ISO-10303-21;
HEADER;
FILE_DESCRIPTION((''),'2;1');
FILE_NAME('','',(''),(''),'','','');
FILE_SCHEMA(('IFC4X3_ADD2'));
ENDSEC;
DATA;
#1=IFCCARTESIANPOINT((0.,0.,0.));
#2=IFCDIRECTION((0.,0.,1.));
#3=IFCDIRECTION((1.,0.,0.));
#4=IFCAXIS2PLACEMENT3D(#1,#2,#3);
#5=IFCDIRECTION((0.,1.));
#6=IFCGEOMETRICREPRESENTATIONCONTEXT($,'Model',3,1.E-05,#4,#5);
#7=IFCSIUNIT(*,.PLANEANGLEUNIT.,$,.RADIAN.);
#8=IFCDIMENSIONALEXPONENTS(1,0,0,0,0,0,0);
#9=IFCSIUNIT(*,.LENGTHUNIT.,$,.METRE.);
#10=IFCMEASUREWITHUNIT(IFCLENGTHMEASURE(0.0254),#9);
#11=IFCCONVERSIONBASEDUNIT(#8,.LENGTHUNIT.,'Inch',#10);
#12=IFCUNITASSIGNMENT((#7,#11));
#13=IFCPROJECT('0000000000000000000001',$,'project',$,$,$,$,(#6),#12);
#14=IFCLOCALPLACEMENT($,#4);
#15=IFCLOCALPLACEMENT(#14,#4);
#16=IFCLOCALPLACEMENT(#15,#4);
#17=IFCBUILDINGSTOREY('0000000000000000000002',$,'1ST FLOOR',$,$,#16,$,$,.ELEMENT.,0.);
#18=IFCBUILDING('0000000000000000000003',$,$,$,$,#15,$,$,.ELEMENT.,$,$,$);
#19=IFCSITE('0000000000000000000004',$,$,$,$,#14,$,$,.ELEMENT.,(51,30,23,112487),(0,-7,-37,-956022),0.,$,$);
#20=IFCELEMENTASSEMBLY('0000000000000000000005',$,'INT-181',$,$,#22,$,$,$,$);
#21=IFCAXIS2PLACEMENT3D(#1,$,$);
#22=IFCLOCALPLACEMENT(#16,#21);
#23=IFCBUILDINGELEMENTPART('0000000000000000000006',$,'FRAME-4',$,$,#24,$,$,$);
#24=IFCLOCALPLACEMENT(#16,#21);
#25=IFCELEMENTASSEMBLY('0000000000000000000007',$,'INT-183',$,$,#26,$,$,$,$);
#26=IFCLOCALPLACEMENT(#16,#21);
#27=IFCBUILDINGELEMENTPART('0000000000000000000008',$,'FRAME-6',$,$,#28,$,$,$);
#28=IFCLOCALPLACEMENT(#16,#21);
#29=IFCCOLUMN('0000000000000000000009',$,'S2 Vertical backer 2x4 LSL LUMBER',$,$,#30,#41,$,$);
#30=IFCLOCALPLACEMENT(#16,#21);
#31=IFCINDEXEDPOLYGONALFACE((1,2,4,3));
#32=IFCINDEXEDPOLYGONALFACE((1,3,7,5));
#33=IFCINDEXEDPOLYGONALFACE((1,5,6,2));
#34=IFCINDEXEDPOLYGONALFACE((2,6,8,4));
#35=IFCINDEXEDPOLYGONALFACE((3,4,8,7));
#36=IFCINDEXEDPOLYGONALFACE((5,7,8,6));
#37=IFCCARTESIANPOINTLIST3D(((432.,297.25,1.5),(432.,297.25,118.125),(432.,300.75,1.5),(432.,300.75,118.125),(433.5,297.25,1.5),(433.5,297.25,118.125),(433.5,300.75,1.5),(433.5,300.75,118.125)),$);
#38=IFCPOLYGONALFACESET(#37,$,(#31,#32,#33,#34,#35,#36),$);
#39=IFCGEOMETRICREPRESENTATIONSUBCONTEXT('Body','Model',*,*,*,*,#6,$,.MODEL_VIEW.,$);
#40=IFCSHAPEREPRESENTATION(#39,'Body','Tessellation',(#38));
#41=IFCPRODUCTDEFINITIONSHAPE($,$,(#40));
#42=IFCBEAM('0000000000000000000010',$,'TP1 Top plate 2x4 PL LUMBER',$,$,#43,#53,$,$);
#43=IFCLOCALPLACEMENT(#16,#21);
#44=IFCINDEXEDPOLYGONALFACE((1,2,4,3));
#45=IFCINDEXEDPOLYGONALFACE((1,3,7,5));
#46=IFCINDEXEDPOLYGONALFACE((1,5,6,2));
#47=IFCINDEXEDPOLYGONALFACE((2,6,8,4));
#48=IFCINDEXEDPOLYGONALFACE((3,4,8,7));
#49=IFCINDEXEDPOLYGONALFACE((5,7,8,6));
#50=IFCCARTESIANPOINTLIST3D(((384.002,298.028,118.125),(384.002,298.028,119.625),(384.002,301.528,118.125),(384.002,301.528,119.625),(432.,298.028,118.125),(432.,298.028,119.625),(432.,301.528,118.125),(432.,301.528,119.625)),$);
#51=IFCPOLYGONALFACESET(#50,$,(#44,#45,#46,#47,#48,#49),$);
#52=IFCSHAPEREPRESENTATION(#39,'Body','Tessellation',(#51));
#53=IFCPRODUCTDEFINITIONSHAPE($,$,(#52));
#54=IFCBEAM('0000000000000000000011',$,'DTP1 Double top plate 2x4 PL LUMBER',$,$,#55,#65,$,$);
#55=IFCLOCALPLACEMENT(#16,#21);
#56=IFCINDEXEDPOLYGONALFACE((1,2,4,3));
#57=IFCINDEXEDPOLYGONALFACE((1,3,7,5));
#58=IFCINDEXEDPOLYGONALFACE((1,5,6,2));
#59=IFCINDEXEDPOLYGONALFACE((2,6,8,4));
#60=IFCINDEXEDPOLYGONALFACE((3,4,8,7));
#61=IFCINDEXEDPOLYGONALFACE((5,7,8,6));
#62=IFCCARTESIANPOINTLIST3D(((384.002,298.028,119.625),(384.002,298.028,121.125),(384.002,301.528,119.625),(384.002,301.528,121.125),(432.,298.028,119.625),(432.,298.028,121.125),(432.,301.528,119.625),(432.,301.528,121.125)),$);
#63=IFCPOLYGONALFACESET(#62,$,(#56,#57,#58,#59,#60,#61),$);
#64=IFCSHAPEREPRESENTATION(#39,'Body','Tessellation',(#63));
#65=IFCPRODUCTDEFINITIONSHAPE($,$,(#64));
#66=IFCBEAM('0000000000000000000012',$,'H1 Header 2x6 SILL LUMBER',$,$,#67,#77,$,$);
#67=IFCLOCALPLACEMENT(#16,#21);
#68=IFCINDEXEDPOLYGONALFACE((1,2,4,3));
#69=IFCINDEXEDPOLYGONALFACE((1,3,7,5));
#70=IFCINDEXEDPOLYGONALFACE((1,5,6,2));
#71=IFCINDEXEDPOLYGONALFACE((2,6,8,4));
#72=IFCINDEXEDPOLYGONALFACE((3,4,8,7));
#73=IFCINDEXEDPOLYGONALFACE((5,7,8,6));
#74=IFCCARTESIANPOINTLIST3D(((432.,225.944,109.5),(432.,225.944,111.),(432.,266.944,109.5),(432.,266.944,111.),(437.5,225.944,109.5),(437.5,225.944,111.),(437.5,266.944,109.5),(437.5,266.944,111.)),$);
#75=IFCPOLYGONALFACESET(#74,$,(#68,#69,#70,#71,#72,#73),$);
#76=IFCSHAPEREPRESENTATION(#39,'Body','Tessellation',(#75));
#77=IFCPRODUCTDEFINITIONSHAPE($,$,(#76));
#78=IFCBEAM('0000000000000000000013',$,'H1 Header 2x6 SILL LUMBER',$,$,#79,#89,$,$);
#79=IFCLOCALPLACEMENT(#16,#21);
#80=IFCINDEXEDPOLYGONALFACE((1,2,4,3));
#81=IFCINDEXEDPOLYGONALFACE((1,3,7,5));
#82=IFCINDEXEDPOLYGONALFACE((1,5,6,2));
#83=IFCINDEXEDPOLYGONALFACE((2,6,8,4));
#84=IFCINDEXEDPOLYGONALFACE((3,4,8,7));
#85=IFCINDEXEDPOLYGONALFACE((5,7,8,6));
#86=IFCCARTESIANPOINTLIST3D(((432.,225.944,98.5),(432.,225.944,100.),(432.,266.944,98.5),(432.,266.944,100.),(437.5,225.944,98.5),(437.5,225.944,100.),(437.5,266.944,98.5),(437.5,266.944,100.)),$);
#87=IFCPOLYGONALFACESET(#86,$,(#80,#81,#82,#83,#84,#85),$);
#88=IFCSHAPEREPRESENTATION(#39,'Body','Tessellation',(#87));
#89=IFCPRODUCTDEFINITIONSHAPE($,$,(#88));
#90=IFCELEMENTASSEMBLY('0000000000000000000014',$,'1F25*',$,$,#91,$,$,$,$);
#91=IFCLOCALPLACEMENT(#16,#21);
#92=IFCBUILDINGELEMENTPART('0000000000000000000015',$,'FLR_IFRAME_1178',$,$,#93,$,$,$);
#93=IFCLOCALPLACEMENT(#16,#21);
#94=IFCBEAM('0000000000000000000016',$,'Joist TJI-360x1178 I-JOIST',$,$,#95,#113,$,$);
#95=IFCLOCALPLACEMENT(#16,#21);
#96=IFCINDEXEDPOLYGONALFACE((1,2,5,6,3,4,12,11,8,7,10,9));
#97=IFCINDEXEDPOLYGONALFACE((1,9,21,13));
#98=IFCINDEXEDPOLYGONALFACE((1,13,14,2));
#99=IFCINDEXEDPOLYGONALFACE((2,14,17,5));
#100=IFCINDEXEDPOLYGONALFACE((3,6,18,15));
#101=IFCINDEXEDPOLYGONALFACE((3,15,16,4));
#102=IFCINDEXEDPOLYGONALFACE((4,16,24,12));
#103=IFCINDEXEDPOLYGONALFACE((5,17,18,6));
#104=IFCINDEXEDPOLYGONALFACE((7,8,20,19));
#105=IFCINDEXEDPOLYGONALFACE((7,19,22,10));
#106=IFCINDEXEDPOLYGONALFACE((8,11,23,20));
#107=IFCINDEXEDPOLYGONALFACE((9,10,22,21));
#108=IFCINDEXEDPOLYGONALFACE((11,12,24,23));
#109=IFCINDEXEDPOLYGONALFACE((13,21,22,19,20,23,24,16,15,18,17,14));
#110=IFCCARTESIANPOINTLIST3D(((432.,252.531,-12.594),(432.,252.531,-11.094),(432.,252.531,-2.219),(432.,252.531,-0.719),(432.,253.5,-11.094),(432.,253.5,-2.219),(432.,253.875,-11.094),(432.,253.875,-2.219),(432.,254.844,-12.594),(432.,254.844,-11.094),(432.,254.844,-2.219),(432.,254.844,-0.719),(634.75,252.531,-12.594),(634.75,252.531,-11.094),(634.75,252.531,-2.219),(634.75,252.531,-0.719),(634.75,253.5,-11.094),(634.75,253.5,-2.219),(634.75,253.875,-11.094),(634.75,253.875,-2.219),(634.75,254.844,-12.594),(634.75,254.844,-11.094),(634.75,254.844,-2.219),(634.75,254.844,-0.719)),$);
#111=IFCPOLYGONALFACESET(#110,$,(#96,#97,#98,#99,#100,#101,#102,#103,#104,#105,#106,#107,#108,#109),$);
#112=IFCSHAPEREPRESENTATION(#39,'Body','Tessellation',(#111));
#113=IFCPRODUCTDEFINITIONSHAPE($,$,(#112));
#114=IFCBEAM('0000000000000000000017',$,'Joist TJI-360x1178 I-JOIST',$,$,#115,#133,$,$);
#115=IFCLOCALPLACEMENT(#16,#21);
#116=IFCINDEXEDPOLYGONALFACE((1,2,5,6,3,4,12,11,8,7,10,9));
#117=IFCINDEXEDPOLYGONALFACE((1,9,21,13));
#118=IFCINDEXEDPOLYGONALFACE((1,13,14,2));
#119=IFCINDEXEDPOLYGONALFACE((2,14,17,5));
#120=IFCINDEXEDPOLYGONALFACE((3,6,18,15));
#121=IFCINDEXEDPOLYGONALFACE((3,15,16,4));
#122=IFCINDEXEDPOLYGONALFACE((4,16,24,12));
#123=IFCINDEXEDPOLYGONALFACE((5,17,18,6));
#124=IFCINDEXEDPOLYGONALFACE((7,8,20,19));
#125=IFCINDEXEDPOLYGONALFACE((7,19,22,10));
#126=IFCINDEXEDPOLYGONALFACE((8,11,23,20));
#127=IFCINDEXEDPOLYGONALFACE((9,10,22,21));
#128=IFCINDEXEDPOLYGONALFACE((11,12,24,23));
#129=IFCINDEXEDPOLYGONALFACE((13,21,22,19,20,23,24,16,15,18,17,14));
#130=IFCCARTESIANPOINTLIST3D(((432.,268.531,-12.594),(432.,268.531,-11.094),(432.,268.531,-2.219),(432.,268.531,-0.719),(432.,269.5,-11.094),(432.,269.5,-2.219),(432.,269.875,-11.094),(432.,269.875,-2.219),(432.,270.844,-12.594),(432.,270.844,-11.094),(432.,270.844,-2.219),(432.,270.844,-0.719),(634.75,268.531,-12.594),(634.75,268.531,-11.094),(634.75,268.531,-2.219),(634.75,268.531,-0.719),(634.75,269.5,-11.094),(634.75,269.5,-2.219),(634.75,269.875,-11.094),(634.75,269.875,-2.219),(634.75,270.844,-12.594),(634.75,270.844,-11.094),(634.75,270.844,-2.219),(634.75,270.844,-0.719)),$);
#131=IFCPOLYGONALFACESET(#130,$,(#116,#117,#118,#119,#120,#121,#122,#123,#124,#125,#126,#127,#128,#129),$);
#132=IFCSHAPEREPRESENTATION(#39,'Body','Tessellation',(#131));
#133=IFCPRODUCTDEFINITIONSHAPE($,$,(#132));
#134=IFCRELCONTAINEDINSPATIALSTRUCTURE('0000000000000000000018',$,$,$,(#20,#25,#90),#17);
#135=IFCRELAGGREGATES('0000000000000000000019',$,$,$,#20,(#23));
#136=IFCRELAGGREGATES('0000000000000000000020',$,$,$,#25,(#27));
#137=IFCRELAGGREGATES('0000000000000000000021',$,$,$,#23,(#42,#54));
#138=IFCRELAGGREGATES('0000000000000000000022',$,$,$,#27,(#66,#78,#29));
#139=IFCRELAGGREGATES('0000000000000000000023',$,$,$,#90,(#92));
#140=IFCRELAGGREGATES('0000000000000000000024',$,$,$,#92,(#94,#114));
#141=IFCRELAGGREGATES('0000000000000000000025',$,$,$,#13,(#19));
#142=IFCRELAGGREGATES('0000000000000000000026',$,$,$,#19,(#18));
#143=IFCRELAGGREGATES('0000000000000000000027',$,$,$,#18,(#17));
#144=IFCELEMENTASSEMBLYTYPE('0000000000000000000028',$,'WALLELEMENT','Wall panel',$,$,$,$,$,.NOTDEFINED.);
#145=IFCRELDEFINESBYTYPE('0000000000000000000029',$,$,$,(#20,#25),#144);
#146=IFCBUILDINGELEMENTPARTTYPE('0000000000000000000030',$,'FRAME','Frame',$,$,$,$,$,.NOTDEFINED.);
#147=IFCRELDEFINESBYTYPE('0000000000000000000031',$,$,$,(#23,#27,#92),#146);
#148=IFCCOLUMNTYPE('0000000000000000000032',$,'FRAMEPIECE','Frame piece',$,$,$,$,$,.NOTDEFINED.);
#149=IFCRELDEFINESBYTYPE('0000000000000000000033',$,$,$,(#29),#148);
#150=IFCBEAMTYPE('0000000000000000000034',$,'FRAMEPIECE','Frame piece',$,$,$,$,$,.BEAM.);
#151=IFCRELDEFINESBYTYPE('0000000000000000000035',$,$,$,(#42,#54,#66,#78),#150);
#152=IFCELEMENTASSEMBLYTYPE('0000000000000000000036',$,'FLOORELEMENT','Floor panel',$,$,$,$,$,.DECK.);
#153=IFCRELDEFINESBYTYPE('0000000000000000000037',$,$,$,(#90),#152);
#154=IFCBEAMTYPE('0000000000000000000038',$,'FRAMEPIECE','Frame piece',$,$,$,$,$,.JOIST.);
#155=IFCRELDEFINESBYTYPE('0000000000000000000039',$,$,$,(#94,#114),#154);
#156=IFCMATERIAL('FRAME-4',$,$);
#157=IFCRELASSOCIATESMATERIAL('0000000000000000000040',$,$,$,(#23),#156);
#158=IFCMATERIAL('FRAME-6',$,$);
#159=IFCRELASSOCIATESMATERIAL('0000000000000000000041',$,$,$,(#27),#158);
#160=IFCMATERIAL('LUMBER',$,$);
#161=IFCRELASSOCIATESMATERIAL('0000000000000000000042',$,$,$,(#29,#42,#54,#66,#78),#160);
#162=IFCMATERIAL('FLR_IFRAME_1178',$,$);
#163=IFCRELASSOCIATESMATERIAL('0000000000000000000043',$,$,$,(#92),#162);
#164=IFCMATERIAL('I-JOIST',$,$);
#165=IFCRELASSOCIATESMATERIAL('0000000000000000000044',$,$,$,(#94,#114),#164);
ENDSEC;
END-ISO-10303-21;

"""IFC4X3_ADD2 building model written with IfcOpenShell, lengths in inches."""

from ifc_helpers import new_model, entity, si_unit, converted_unit, direction, frame, origin_with_axes, origin_2d_with_axis, place, context, subcontext, project, spatial, rectangle, i_section, extrude, material, type_object, element, aggregate, save


model = new_model("IFC4X3_ADD2")

# Units and contexts
model_context = context("Model", 3, precision=1e-05, world=origin_with_axes(), true_north=direction((0.0, 1.0)))
body_context = subcontext(model_context, "Body", "Model", "MODEL_VIEW")
ifc_project = project(units=[si_unit("PLANEANGLEUNIT", "RADIAN"), converted_unit("LENGTHUNIT", "Inch", entity("IfcLengthMeasure", 0.0254), si_unit("LENGTHUNIT", "METRE"), dimensions=[1, 0, 0, 0, 0, 0, 0])], contexts=[model_context])

# Site, building, storey
site_placement = place(None, origin_with_axes())
site = spatial("IfcSite", under=ifc_project, at=site_placement, CompositionType="ELEMENT", RefLatitude=(51, 30, 23, 112487), RefLongitude=(0, -7, -37, -956022), RefElevation=0.0)
building_placement = place(site_placement, origin_with_axes())
building = spatial("IfcBuilding", under=site, at=building_placement, CompositionType="ELEMENT")
storey_placement = place(building_placement, origin_with_axes())
storey = spatial("IfcBuildingStorey", under=building, at=storey_placement, Name="1ST FLOOR", CompositionType="ELEMENT", Elevation=0.0)

# Element assemblies, building element parts, column
element_assembly_type_1 = type_object("IfcElementAssemblyType", Name="WALLELEMENT", Description="Wall panel", PredefinedType="NOTDEFINED")
ifc_material_1 = material(Name="FRAME-4")
building_element_part_type = type_object("IfcBuildingElementPartType", Name="FRAME", Description="Frame", PredefinedType="NOTDEFINED")
ifc_material_2 = material(Name="LUMBER")
column_type = type_object("IfcColumnType", Name="FRAMEPIECE", Description="Frame piece", PredefinedType="NOTDEFINED")
assembly_1_placement = place(storey_placement, origin_with_axes())
assembly_1 = element("IfcElementAssembly", 1, at=assembly_1_placement, inside=storey, type_object=element_assembly_type_1, Name="INT-181")
building_element_part_1_placement = place(storey_placement, origin_with_axes())
building_element_part_1 = element("IfcBuildingElementPart", 2, at=building_element_part_1_placement, type_object=building_element_part_type, material=ifc_material_1, Name="FRAME-4")
aggregate(assembly_1, [building_element_part_1])
assembly_2_placement = place(storey_placement, origin_with_axes())
assembly_2 = element("IfcElementAssembly", 3, at=assembly_2_placement, inside=storey, type_object=element_assembly_type_1, Name="INT-183")
ifc_material_3 = material(Name="FRAME-6")
building_element_part_2_placement = place(storey_placement, origin_with_axes())
building_element_part_2 = element("IfcBuildingElementPart", 4, at=building_element_part_2_placement, type_object=building_element_part_type, material=ifc_material_3, Name="FRAME-6")
aggregate(assembly_2, [building_element_part_2])
column_1_placement = place(storey_placement, frame((432.75, 299.0, 1.5), z_axis=(0.0, 0.0, 1.0), x_axis=(-1.0, 0.0, 0.0)))
column_1 = element("IfcColumn", 5, at=column_1_placement, type_object=column_type, material=ifc_material_2, Name="S2 Vertical backer 2x4 LSL LUMBER", context=body_context, shape_type="SweptSolid", body=[
    extrude(rectangle(XDim=1.5, YDim=3.5, at=origin_2d_with_axis()), origin_with_axes(), (0.0, 0.0, 1.0), 116.625),
])

# Beams
beam_type_1 = type_object("IfcBeamType", Name="FRAMEPIECE", Description="Frame piece", PredefinedType="BEAM")
beam_1_placement = place(storey_placement, frame((384.002, 299.778, 118.875), z_axis=(1.0, 0.0, 0.0), x_axis=(0.0, 0.0, -1.0)))
beam_1 = element("IfcBeam", 6, at=beam_1_placement, type_object=beam_type_1, material=ifc_material_2, Name="TP1 Top plate 2x4 PL LUMBER", context=body_context, shape_type="SweptSolid", body=[
    extrude(rectangle(XDim=1.5, YDim=3.5, at=origin_2d_with_axis()), origin_with_axes(), (0.0, 0.0, 1.0), 47.998),
])
beam_2_placement = place(storey_placement, frame((384.002, 299.778, 120.375), z_axis=(1.0, 0.0, 0.0), x_axis=(0.0, 0.0, -1.0)))
beam_2 = element("IfcBeam", 7, at=beam_2_placement, type_object=beam_type_1, material=ifc_material_2, Name="DTP1 Double top plate 2x4 PL LUMBER", context=body_context, shape_type="SweptSolid", body=[
    extrude(rectangle(XDim=1.5, YDim=3.5, at=origin_2d_with_axis()), origin_with_axes(), (0.0, 0.0, 1.0), 47.998),
])
aggregate(building_element_part_1, [beam_1, beam_2])
beam_3_placement = place(storey_placement, frame((434.75, 266.944, 110.25), z_axis=(0.0, -1.0, 0.0), x_axis=(0.0, 0.0, 1.0)))
beam_3 = element("IfcBeam", 8, at=beam_3_placement, type_object=beam_type_1, material=ifc_material_2, Name="H1 Header 2x6 SILL LUMBER", context=body_context, shape_type="SweptSolid", body=[
    extrude(rectangle(XDim=1.5, YDim=5.5, at=origin_2d_with_axis()), origin_with_axes(), (0.0, 0.0, 1.0), 41.0),
])
beam_4_placement = place(storey_placement, frame((434.75, 266.944, 99.25), z_axis=(0.0, -1.0, 0.0), x_axis=(0.0, 0.0, 1.0)))
beam_4 = element("IfcBeam", 9, at=beam_4_placement, type_object=beam_type_1, material=ifc_material_2, Name="H1 Header 2x6 SILL LUMBER", context=body_context, shape_type="SweptSolid", body=[
    extrude(rectangle(XDim=1.5, YDim=5.5, at=origin_2d_with_axis()), origin_with_axes(), (0.0, 0.0, 1.0), 41.0),
])
aggregate(building_element_part_2, [beam_3, beam_4, column_1])

# Element assembly, building element part, beams
element_assembly_type_2 = type_object("IfcElementAssemblyType", Name="FLOORELEMENT", Description="Floor panel", PredefinedType="DECK")
assembly_3_placement = place(storey_placement, origin_with_axes())
assembly_3 = element("IfcElementAssembly", 10, at=assembly_3_placement, inside=storey, type_object=element_assembly_type_2, Name="1F25*")
ifc_material_4 = material(Name="FLR_IFRAME_1178")
building_element_part_3_placement = place(storey_placement, origin_with_axes())
building_element_part_3 = element("IfcBuildingElementPart", 11, at=building_element_part_3_placement, type_object=building_element_part_type, material=ifc_material_4, Name="FLR_IFRAME_1178")
aggregate(assembly_3, [building_element_part_3])
ifc_material_5 = material(Name="I-JOIST")
beam_type_2 = type_object("IfcBeamType", Name="FRAMEPIECE", Description="Frame piece", PredefinedType="JOIST")
beam_5_placement = place(storey_placement, frame((432.0, 253.688, -6.656), z_axis=(1.0, 0.0, 0.0), x_axis=(0.0, 1.0, 0.0)))
beam_5 = element("IfcBeam", 12, at=beam_5_placement, type_object=beam_type_2, material=ifc_material_5, Name="Joist TJI-360x1178 I-JOIST", context=body_context, shape_type="SweptSolid", body=[
    extrude(i_section(OverallWidth=2.313, OverallDepth=11.875, WebThickness=0.375, FlangeThickness=1.5, at=origin_2d_with_axis()), origin_with_axes(), (0.0, 0.0, 1.0), 202.75),
])
beam_6_placement = place(storey_placement, frame((432.0, 269.688, -6.656), z_axis=(1.0, 0.0, 0.0), x_axis=(0.0, 1.0, 0.0)))
beam_6 = element("IfcBeam", 13, at=beam_6_placement, type_object=beam_type_2, material=ifc_material_5, Name="Joist TJI-360x1178 I-JOIST", context=body_context, shape_type="SweptSolid", body=[
    extrude(i_section(OverallWidth=2.313, OverallDepth=11.875, WebThickness=0.375, FlangeThickness=1.5, at=origin_2d_with_axis()), origin_with_axes(), (0.0, 0.0, 1.0), 202.75),
])
aggregate(building_element_part_3, [beam_5, beam_6])

save(model, "model.ifc")
